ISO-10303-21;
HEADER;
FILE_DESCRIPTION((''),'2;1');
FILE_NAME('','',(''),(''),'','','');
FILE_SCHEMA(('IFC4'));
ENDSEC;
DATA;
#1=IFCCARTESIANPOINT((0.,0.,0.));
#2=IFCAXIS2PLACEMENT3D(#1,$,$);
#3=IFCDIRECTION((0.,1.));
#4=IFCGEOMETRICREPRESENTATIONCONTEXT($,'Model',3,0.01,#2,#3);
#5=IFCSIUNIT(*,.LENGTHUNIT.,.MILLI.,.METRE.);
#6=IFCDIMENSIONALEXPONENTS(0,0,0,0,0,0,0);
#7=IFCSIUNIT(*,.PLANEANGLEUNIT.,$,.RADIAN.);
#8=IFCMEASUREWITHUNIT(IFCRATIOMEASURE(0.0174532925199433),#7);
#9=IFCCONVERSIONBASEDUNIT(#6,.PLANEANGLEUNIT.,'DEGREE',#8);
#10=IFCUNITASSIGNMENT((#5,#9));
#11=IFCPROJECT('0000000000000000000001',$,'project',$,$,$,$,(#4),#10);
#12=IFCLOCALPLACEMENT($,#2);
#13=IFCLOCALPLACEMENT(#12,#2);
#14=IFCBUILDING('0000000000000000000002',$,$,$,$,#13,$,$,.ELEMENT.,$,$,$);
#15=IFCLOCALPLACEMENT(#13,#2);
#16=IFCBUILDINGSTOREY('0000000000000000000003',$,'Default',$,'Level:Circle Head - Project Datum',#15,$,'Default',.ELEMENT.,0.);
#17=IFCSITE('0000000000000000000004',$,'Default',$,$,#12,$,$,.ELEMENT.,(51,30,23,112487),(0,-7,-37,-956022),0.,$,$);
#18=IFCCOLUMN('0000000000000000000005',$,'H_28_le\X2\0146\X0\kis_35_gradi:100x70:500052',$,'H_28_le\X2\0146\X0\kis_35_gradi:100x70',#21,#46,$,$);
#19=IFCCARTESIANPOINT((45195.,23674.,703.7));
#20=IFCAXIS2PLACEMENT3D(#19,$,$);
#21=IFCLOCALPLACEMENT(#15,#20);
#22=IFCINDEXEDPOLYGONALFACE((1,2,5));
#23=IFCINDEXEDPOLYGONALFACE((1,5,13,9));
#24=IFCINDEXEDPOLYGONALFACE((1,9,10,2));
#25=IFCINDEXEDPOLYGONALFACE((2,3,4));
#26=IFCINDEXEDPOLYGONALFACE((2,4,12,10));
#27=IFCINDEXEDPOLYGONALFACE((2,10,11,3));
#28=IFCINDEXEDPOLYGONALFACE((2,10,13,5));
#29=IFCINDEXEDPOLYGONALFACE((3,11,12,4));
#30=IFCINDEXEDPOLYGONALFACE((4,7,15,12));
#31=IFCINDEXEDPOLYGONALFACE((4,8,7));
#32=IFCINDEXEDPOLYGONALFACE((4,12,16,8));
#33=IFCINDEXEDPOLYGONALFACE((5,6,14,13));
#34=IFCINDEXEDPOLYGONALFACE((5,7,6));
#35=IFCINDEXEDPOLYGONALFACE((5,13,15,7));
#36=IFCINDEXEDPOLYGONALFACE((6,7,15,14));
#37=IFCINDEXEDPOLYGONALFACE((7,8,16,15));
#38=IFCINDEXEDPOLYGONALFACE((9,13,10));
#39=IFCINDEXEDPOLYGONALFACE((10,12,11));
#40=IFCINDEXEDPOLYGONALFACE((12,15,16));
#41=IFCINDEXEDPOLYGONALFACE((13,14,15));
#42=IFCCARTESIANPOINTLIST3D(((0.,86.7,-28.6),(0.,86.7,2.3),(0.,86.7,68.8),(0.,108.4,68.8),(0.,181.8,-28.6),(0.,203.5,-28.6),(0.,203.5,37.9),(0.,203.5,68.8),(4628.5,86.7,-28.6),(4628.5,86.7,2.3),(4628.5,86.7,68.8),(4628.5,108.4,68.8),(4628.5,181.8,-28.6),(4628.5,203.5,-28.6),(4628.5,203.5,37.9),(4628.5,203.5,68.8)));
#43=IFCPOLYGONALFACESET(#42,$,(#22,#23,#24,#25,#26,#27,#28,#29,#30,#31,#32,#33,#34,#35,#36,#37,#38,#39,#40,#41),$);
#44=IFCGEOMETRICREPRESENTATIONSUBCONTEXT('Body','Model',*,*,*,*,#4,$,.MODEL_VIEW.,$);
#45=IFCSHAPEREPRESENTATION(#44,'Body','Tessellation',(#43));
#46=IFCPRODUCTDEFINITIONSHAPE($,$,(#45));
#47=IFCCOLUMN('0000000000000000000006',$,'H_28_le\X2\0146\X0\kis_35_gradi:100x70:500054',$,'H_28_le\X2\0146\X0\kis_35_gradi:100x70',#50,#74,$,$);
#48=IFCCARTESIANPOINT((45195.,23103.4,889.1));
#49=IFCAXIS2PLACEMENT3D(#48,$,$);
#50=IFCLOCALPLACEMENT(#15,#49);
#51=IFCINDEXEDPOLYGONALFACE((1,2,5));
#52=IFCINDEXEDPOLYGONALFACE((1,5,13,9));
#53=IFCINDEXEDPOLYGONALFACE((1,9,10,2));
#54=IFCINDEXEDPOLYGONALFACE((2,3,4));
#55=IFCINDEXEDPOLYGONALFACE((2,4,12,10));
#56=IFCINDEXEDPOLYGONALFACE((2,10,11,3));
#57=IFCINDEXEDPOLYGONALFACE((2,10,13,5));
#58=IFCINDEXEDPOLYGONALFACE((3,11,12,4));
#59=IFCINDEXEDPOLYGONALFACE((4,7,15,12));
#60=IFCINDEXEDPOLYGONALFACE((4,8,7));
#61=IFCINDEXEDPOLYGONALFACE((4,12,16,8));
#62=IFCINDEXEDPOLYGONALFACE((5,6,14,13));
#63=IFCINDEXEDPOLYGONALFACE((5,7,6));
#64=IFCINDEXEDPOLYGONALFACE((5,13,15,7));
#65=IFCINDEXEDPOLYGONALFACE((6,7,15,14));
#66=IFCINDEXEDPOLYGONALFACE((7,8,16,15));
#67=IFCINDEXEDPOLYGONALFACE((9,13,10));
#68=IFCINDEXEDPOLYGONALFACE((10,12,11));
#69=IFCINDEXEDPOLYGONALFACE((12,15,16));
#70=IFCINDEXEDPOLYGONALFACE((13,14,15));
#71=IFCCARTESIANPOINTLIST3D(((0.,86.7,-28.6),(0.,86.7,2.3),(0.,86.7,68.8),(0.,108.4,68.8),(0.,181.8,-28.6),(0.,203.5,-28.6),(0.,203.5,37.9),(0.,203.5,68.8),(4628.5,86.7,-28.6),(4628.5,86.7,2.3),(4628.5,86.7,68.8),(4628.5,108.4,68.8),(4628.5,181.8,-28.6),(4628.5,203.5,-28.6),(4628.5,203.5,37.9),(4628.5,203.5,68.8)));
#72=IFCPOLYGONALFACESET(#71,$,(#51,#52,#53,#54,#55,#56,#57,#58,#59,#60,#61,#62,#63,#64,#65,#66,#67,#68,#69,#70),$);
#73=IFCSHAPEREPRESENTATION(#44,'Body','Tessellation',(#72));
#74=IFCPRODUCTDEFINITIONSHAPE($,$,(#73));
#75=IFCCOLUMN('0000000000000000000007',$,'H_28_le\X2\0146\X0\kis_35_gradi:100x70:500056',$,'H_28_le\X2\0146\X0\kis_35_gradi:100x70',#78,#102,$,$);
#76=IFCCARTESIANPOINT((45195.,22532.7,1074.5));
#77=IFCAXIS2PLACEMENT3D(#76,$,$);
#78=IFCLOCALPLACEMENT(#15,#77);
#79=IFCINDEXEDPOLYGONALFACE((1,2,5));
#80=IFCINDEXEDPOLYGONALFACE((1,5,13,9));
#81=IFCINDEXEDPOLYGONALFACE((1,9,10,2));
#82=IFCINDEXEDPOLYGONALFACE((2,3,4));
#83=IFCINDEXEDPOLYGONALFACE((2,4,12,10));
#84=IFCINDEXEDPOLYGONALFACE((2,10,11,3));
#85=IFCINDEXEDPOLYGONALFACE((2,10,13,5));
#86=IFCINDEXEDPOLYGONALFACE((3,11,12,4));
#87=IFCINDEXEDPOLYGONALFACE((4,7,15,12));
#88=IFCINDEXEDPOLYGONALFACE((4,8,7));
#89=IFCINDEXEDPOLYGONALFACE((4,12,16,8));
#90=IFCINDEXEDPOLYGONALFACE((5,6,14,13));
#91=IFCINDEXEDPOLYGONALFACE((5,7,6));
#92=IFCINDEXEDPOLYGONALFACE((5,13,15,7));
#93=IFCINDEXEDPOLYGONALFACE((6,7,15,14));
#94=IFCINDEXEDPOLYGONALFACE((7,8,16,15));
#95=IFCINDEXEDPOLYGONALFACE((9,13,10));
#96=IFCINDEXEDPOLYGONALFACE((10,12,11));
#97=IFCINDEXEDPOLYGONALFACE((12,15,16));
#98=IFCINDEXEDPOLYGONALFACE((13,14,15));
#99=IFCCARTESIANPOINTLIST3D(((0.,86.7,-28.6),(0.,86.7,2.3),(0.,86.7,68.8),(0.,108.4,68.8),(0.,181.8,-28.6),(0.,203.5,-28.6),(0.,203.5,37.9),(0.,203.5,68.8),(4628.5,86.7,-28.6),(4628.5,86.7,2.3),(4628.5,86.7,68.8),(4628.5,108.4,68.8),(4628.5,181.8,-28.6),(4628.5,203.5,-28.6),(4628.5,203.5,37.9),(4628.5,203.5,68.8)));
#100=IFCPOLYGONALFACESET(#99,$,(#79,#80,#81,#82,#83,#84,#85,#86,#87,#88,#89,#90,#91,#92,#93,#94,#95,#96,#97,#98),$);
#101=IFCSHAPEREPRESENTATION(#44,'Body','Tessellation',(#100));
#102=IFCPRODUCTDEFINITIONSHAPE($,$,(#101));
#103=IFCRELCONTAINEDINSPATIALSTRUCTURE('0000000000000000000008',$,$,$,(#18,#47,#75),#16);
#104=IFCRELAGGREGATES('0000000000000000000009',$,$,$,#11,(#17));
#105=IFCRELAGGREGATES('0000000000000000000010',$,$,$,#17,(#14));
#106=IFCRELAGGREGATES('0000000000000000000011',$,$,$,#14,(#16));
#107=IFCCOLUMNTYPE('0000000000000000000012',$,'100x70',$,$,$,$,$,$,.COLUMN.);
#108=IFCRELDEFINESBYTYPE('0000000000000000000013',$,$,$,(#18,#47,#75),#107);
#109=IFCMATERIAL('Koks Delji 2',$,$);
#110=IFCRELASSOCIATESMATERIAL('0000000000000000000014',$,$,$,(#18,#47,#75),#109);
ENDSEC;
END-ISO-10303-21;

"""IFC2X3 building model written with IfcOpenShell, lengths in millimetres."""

from ifc_helpers import new_model, entity, si_unit, converted_unit, direction, frame, frame_2d, origin, origin_2d_with_axis, place, context, subcontext, project, spatial, rectangle, extrude, boolean, source, transform, mapped, material, type_object, type_shapes, element, save


model = new_model("IFC2X3")

# Units and contexts
model_context = context("Model", 3, precision=0.01, world=origin(), true_north=direction((0.0, 1.0)))
body_context = subcontext(model_context, "Body", "Model", "MODEL_VIEW")
ifc_project = project(units=[si_unit("LENGTHUNIT", "METRE", prefix="MILLI"), converted_unit("PLANEANGLEUNIT", "DEGREE", entity("IfcRatioMeasure", 0.0174532925199433), si_unit("PLANEANGLEUNIT", "RADIAN"), dimensions=[0, 0, 0, 0, 0, 0, 0])], contexts=[model_context])

# Site, building, storey
site_placement = place(None, origin())
site = spatial("IfcSite", under=ifc_project, at=site_placement, Name="Default", CompositionType="ELEMENT", RefLatitude=(51, 30, 23, 112487), RefLongitude=(0, -7, -37, -956022), RefElevation=0.0)
building_placement = place(site_placement, origin())
building = spatial("IfcBuilding", under=site, at=building_placement, CompositionType="ELEMENT")
storey_placement = place(building_placement, origin())
storey = spatial("IfcBuildingStorey", under=building, at=storey_placement, Name="Default", ObjectType="Level:Circle Head - Project Datum", LongName="Default", CompositionType="ELEMENT", Elevation=0.0)

# Columns
ifc_material_1 = material(Name="Koks Delji 2")
column_type = type_object("IfcColumnType", Name="100x70", PredefinedType="COLUMN")
shared_shape_1 = source(origin(), body_context, "Body", "CSG", [
    boolean("DIFFERENCE", extrude(rectangle(XDim=4628.5, YDim=116.7, at=origin_2d_with_axis()), frame((2314.3, 145.1, -28.6)), (0.0, 0.0, 1.0), 97.5), extrude(rectangle(XDim=70.0, YDim=100.0, at=frame_2d((0.0, 0.0), x_axis=(0.0, 1.0))), frame((4628.5, 145.1, 20.1), z_axis=(1.0, 0.0, 0.0), x_axis=(0.0, 0.951057, -0.309017)), (0.0, 0.0, -1.0), 4628.5)),
])
type_shapes(column_type, [shared_shape_1])
for number, where, name in (
    (1, (45195.0, 23674.0, 703.7), "H_28_leņkis_35_gradi:100x70:500052"),
    (2, (45195.0, 23103.4, 889.1), "H_28_leņkis_35_gradi:100x70:500054"),
    (3, (45195.0, 22532.7, 1074.5), "H_28_leņkis_35_gradi:100x70:500056"),
):
    element("IfcColumn", number, at=place(storey_placement, frame(where)), inside=storey, type_object=column_type, material=ifc_material_1, Name=name, ObjectType="H_28_leņkis_35_gradi:100x70", context=body_context, shape_type="MappedRepresentation", body=[
        mapped(shared_shape_1, transform((0.0, 0.0, 0.0), scale=1.0)),
    ])

save(model, "model.ifc")
